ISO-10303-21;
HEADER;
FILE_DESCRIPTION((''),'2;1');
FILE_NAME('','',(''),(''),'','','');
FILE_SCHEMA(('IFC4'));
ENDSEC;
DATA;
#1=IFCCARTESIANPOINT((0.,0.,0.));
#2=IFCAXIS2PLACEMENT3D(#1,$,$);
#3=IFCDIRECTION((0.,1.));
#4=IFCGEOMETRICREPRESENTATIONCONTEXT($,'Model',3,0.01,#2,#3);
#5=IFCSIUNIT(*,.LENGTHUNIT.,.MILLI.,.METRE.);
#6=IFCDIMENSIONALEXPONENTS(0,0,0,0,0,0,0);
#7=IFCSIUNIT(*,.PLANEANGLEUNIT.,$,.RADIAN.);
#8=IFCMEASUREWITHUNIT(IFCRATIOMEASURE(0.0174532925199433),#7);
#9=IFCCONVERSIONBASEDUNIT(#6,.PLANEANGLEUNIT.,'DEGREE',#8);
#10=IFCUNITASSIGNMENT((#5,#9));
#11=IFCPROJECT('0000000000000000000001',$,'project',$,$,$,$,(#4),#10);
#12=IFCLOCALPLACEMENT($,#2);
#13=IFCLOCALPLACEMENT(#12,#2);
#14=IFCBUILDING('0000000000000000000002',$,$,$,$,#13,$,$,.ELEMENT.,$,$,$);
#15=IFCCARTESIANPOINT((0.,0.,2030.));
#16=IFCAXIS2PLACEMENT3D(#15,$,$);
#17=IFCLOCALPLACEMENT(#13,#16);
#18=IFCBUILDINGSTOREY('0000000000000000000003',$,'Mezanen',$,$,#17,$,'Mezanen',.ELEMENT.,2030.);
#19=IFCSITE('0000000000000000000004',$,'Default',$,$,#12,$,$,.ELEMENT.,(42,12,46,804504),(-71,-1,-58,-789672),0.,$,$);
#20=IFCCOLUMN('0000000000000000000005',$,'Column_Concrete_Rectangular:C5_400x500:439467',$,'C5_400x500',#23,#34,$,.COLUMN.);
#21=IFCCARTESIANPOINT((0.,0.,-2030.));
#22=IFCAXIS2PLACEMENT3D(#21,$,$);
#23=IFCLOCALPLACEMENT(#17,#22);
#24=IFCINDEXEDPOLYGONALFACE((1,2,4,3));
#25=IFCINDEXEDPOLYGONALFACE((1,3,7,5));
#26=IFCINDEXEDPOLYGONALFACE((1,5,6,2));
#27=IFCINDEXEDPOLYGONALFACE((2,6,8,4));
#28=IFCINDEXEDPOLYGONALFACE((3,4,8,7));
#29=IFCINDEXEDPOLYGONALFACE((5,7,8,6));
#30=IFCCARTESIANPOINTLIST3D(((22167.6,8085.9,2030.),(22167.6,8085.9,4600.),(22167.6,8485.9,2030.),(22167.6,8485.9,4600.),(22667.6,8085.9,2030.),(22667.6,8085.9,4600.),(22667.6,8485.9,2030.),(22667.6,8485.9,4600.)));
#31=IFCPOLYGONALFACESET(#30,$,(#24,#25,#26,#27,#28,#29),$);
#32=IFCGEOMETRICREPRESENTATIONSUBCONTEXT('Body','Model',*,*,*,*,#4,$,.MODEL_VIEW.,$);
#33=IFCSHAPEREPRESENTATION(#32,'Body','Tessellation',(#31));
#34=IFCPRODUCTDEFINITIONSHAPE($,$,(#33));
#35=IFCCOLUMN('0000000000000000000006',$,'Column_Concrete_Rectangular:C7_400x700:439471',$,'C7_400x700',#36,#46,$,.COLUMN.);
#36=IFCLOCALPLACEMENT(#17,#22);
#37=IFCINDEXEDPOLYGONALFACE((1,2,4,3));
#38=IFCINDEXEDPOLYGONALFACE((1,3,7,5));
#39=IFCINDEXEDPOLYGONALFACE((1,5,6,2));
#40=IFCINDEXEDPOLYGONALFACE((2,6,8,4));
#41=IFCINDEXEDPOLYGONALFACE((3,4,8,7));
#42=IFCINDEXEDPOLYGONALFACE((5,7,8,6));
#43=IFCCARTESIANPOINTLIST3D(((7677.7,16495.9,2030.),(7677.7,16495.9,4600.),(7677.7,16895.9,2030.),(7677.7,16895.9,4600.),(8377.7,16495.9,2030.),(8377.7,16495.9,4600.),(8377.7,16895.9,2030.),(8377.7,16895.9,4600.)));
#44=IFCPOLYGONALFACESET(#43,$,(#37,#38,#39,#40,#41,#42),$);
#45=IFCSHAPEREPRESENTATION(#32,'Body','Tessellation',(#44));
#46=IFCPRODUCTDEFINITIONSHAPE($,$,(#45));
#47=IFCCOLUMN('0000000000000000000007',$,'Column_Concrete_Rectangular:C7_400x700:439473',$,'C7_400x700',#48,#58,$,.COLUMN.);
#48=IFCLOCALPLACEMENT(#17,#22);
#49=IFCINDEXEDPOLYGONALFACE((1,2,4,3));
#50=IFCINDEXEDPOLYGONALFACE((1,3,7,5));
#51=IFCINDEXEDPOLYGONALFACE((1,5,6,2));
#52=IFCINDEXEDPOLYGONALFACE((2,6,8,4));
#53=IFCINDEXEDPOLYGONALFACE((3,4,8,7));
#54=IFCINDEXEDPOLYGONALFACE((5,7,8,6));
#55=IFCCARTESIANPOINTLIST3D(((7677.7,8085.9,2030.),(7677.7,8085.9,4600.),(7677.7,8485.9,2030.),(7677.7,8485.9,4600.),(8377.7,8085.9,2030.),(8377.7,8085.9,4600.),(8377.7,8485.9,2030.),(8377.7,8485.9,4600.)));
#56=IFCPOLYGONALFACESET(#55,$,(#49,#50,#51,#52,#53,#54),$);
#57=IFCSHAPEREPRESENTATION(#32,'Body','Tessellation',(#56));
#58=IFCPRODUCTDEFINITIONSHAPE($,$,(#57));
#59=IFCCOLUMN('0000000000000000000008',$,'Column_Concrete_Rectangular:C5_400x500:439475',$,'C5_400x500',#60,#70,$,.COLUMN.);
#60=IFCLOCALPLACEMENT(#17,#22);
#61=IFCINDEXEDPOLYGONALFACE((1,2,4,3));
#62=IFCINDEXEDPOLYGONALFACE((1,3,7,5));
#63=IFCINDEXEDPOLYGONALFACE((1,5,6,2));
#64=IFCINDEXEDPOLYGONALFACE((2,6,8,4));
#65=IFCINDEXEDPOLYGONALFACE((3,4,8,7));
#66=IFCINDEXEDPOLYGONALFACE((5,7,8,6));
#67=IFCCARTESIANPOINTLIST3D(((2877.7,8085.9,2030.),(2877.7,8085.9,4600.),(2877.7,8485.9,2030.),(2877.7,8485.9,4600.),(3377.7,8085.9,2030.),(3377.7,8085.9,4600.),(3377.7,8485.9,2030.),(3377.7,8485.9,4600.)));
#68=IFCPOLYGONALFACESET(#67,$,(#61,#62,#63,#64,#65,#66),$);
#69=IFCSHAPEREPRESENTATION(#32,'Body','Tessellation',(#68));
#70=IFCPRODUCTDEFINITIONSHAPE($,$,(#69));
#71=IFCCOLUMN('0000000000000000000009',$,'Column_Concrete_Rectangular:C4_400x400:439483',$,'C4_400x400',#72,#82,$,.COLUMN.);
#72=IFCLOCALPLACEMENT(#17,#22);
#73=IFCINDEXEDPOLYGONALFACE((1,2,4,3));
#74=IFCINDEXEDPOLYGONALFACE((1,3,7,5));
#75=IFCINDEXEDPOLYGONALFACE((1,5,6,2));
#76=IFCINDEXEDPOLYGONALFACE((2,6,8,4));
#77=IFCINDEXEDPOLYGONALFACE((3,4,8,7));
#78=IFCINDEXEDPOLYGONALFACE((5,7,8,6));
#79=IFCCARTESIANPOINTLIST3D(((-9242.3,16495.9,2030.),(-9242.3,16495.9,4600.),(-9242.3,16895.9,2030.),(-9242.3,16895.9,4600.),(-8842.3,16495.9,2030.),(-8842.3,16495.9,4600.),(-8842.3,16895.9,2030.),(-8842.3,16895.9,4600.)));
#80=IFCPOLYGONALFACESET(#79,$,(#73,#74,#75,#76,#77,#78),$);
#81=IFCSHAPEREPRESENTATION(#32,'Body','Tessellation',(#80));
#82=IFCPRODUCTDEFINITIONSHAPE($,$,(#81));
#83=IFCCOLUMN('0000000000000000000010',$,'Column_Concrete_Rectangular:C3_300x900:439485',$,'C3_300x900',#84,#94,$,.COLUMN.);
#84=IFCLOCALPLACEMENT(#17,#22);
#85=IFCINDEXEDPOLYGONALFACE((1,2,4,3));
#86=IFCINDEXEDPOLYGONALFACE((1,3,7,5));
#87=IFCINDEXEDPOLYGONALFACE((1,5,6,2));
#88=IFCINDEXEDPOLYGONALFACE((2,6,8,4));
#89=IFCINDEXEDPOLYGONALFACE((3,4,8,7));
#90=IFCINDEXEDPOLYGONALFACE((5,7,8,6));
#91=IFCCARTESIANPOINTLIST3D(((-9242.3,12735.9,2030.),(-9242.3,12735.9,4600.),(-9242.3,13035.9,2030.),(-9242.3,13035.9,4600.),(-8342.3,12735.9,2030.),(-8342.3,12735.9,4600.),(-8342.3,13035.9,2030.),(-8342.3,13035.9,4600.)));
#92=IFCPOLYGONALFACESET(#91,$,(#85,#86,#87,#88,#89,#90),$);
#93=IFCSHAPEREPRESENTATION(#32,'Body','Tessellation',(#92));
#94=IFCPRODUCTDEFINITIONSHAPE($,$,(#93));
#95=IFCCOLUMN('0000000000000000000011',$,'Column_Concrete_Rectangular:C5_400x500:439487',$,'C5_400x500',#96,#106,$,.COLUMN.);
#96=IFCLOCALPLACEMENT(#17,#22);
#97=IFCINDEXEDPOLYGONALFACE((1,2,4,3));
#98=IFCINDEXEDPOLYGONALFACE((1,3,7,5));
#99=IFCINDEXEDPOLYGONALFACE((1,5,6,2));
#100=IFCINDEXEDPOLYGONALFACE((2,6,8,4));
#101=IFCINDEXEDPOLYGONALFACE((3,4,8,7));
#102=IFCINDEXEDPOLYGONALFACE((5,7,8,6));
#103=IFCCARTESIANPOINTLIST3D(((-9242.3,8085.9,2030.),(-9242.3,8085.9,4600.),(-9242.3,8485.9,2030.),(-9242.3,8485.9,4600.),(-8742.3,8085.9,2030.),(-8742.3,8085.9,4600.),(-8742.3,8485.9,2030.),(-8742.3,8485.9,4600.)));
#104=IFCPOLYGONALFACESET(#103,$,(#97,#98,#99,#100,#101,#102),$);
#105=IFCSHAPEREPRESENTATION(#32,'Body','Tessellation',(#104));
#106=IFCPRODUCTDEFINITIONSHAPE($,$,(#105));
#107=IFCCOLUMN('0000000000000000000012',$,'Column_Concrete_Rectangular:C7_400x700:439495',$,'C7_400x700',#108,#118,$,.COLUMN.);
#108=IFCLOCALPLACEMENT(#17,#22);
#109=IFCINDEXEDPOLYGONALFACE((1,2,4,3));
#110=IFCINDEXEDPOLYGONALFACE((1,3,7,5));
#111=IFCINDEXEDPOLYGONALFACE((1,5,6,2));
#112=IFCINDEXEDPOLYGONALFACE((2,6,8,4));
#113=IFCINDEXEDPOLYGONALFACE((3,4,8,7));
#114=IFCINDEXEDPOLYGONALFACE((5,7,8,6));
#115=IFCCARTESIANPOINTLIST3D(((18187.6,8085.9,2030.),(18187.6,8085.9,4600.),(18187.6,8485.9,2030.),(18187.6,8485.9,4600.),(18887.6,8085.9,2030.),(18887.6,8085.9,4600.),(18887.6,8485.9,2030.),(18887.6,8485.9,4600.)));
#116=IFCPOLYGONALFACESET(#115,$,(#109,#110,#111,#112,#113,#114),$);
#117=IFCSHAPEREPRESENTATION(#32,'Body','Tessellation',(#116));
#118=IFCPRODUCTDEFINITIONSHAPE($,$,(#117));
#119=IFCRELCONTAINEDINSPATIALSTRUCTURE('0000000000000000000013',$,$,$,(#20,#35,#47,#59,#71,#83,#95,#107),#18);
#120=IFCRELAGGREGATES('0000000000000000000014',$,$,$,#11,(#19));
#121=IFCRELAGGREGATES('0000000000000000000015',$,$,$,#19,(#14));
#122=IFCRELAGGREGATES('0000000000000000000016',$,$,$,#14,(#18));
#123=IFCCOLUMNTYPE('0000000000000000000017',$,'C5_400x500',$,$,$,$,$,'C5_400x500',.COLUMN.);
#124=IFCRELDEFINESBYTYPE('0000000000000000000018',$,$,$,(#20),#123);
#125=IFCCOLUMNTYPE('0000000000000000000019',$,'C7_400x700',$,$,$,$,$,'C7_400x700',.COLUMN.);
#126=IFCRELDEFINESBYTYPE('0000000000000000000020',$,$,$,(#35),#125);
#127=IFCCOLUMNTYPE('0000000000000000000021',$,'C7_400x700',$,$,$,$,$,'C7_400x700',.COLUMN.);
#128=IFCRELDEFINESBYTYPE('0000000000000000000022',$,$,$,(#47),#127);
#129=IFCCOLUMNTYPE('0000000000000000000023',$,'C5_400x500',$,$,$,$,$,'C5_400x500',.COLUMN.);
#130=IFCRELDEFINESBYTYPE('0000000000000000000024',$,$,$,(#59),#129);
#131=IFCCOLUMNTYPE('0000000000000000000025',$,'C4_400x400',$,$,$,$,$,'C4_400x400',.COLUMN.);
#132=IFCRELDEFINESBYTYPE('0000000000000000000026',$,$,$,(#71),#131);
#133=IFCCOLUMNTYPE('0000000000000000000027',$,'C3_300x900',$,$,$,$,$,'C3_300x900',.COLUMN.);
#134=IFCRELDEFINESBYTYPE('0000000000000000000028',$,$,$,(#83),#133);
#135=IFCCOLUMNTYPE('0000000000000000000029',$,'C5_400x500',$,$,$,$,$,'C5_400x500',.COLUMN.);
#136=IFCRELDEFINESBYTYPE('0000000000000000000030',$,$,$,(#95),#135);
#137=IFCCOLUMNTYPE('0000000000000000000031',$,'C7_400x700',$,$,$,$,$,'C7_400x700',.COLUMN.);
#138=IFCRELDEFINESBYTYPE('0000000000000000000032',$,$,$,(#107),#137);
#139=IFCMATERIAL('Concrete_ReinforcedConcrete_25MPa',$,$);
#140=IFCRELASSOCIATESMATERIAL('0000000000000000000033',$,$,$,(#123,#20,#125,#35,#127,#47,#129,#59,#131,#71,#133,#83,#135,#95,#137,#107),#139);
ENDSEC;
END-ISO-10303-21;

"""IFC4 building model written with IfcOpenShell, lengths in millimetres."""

from ifc_helpers import new_model, entity, si_unit, converted_unit, direction, frame, frame_2d, origin, origin_2d_with_axis, place, context, subcontext, project, spatial, rectangle, extrude, source, transform, mapped, material, type_object, type_shapes, element, save


model = new_model("IFC4")

# Units and contexts
model_context = context("Model", 3, precision=0.01, world=origin(), true_north=direction((0.0, 1.0)))
body_context = subcontext(model_context, "Body", "Model", "MODEL_VIEW")
ifc_project = project(units=[si_unit("LENGTHUNIT", "METRE", prefix="MILLI"), converted_unit("PLANEANGLEUNIT", "DEGREE", entity("IfcRatioMeasure", 0.0174532925199433), si_unit("PLANEANGLEUNIT", "RADIAN"), dimensions=[0, 0, 0, 0, 0, 0, 0])], contexts=[model_context])

# Site, building, storey
site_placement = place(None, origin())
site = spatial("IfcSite", under=ifc_project, at=site_placement, Name="Default", CompositionType="ELEMENT", RefLatitude=(42, 12, 46, 804504), RefLongitude=(-71, -1, -58, -789672), RefElevation=0.0)
building_placement = place(site_placement, origin())
building = spatial("IfcBuilding", under=site, at=building_placement, CompositionType="ELEMENT")
storey_placement = place(building_placement, frame((0.0, 0.0, 2030.0)))
storey = spatial("IfcBuildingStorey", under=building, at=storey_placement, Name="Mezanen", LongName="Mezanen", CompositionType="ELEMENT", Elevation=2030.0)

# Columns
ifc_material = material(Name="Concrete_ReinforcedConcrete_25MPa")
column_type_1 = type_object("IfcColumnType", Name="C5_400x500", ElementType="C5_400x500", PredefinedType="COLUMN", material=ifc_material)
shared_shape_1 = source(origin(), body_context, "Body", "SweptSolid", [
    extrude(rectangle(XDim=400.0, YDim=500.0, at=frame_2d((0.0, 0.0), x_axis=(1.0, 0.0))), frame((22417.6, 8285.9, 2030.0), z_axis=(0.0, 0.0, 1.0), x_axis=(0.0, -1.0, 0.0)), (0.0, 0.0, 1.0), 2570.0),
])
type_shapes(column_type_1, [shared_shape_1])
column_1_placement = place(storey_placement, frame((0.0, 0.0, -2030.0)))
element("IfcColumn", 1, at=column_1_placement, inside=storey, type_object=column_type_1, material=ifc_material, Name="Column_Concrete_Rectangular:C5_400x500:439467", ObjectType="C5_400x500", PredefinedType="COLUMN", context=body_context, shape_type="MappedRepresentation", body=[
    mapped(shared_shape_1, transform((0.0, 0.0, 0.0), scale=1.0)),
])
column_type_2 = type_object("IfcColumnType", Name="C7_400x700", ElementType="C7_400x700", PredefinedType="COLUMN", material=ifc_material)
shared_shape_2 = source(origin(), body_context, "Body", "SweptSolid", [
    extrude(rectangle(XDim=400.0, YDim=700.0, at=frame_2d((0.0, 0.0), x_axis=(1.0, 0.0))), frame((8027.7, 16695.9, 2030.0), z_axis=(0.0, 0.0, 1.0), x_axis=(0.0, -1.0, 0.0)), (0.0, 0.0, 1.0), 2570.0),
])
type_shapes(column_type_2, [shared_shape_2])
column_2_placement = place(storey_placement, frame((0.0, 0.0, -2030.0)))
element("IfcColumn", 2, at=column_2_placement, inside=storey, type_object=column_type_2, material=ifc_material, Name="Column_Concrete_Rectangular:C7_400x700:439471", ObjectType="C7_400x700", PredefinedType="COLUMN", context=body_context, shape_type="MappedRepresentation", body=[
    mapped(shared_shape_2, transform((0.0, 0.0, 0.0), scale=1.0)),
])
column_type_3 = type_object("IfcColumnType", Name="C7_400x700", ElementType="C7_400x700", PredefinedType="COLUMN", material=ifc_material)
shared_shape_3 = source(origin(), body_context, "Body", "SweptSolid", [
    extrude(rectangle(XDim=400.0, YDim=700.0, at=origin_2d_with_axis()), frame((8027.7, 8285.9, 2030.0), z_axis=(0.0, 0.0, 1.0), x_axis=(0.0, -1.0, 0.0)), (0.0, 0.0, 1.0), 2570.0),
])
type_shapes(column_type_3, [shared_shape_3])
column_3_placement = place(storey_placement, frame((0.0, 0.0, -2030.0)))
element("IfcColumn", 3, at=column_3_placement, inside=storey, type_object=column_type_3, material=ifc_material, Name="Column_Concrete_Rectangular:C7_400x700:439473", ObjectType="C7_400x700", PredefinedType="COLUMN", context=body_context, shape_type="MappedRepresentation", body=[
    mapped(shared_shape_3, transform((0.0, 0.0, 0.0), scale=1.0)),
])
column_type_4 = type_object("IfcColumnType", Name="C5_400x500", ElementType="C5_400x500", PredefinedType="COLUMN", material=ifc_material)
shared_shape_4 = source(origin(), body_context, "Body", "SweptSolid", [
    extrude(rectangle(XDim=400.0, YDim=500.0, at=origin_2d_with_axis()), frame((3127.7, 8285.9, 2030.0), z_axis=(0.0, 0.0, 1.0), x_axis=(0.0, -1.0, 0.0)), (0.0, 0.0, 1.0), 2570.0),
])
type_shapes(column_type_4, [shared_shape_4])
column_4_placement = place(storey_placement, frame((0.0, 0.0, -2030.0)))
element("IfcColumn", 4, at=column_4_placement, inside=storey, type_object=column_type_4, material=ifc_material, Name="Column_Concrete_Rectangular:C5_400x500:439475", ObjectType="C5_400x500", PredefinedType="COLUMN", context=body_context, shape_type="MappedRepresentation", body=[
    mapped(shared_shape_4, transform((0.0, 0.0, 0.0), scale=1.0)),
])
column_type_5 = type_object("IfcColumnType", Name="C4_400x400", ElementType="C4_400x400", PredefinedType="COLUMN", material=ifc_material)
shared_shape_5 = source(origin(), body_context, "Body", "SweptSolid", [
    extrude(rectangle(XDim=400.0, YDim=400.0, at=origin_2d_with_axis()), frame((-9042.3, 16695.9, 2030.0), z_axis=(0.0, 0.0, 1.0), x_axis=(0.0, -1.0, 0.0)), (0.0, 0.0, 1.0), 2570.0),
])
type_shapes(column_type_5, [shared_shape_5])
column_5_placement = place(storey_placement, frame((0.0, 0.0, -2030.0)))
element("IfcColumn", 5, at=column_5_placement, inside=storey, type_object=column_type_5, material=ifc_material, Name="Column_Concrete_Rectangular:C4_400x400:439483", ObjectType="C4_400x400", PredefinedType="COLUMN", context=body_context, shape_type="MappedRepresentation", body=[
    mapped(shared_shape_5, transform((0.0, 0.0, 0.0), scale=1.0)),
])
column_type_6 = type_object("IfcColumnType", Name="C3_300x900", ElementType="C3_300x900", PredefinedType="COLUMN", material=ifc_material)
shared_shape_6 = source(origin(), body_context, "Body", "SweptSolid", [
    extrude(rectangle(XDim=300.0, YDim=900.0, at=frame_2d((0.0, 0.0), x_axis=(1.0, 0.0))), frame((-8792.3, 12885.9, 2030.0), z_axis=(0.0, 0.0, 1.0), x_axis=(0.0, -1.0, 0.0)), (0.0, 0.0, 1.0), 2570.0),
])
type_shapes(column_type_6, [shared_shape_6])
column_6_placement = place(storey_placement, frame((0.0, 0.0, -2030.0)))
element("IfcColumn", 6, at=column_6_placement, inside=storey, type_object=column_type_6, material=ifc_material, Name="Column_Concrete_Rectangular:C3_300x900:439485", ObjectType="C3_300x900", PredefinedType="COLUMN", context=body_context, shape_type="MappedRepresentation", body=[
    mapped(shared_shape_6, transform((0.0, 0.0, 0.0), scale=1.0)),
])
column_type_7 = type_object("IfcColumnType", Name="C5_400x500", ElementType="C5_400x500", PredefinedType="COLUMN", material=ifc_material)
shared_shape_7 = source(origin(), body_context, "Body", "SweptSolid", [
    extrude(rectangle(XDim=400.0, YDim=500.0, at=frame_2d((0.0, 0.0), x_axis=(1.0, 0.0))), frame((-8992.3, 8285.9, 2030.0), z_axis=(0.0, 0.0, 1.0), x_axis=(0.0, -1.0, 0.0)), (0.0, 0.0, 1.0), 2570.0),
])
type_shapes(column_type_7, [shared_shape_7])
column_7_placement = place(storey_placement, frame((0.0, 0.0, -2030.0)))
element("IfcColumn", 7, at=column_7_placement, inside=storey, type_object=column_type_7, material=ifc_material, Name="Column_Concrete_Rectangular:C5_400x500:439487", ObjectType="C5_400x500", PredefinedType="COLUMN", context=body_context, shape_type="MappedRepresentation", body=[
    mapped(shared_shape_7, transform((0.0, 0.0, 0.0), scale=1.0)),
])
column_type_8 = type_object("IfcColumnType", Name="C7_400x700", ElementType="C7_400x700", PredefinedType="COLUMN", material=ifc_material)
shared_shape_8 = source(origin(), body_context, "Body", "SweptSolid", [
    extrude(rectangle(XDim=400.0, YDim=700.0, at=origin_2d_with_axis()), frame((18537.6, 8285.9, 2030.0), z_axis=(0.0, 0.0, 1.0), x_axis=(0.0, -1.0, 0.0)), (0.0, 0.0, 1.0), 2570.0),
])
type_shapes(column_type_8, [shared_shape_8])
column_8_placement = place(storey_placement, frame((0.0, 0.0, -2030.0)))
element("IfcColumn", 8, at=column_8_placement, inside=storey, type_object=column_type_8, material=ifc_material, Name="Column_Concrete_Rectangular:C7_400x700:439495", ObjectType="C7_400x700", PredefinedType="COLUMN", context=body_context, shape_type="MappedRepresentation", body=[
    mapped(shared_shape_8, transform((0.0, 0.0, 0.0), scale=1.0)),
])

save(model, "model.ifc")
